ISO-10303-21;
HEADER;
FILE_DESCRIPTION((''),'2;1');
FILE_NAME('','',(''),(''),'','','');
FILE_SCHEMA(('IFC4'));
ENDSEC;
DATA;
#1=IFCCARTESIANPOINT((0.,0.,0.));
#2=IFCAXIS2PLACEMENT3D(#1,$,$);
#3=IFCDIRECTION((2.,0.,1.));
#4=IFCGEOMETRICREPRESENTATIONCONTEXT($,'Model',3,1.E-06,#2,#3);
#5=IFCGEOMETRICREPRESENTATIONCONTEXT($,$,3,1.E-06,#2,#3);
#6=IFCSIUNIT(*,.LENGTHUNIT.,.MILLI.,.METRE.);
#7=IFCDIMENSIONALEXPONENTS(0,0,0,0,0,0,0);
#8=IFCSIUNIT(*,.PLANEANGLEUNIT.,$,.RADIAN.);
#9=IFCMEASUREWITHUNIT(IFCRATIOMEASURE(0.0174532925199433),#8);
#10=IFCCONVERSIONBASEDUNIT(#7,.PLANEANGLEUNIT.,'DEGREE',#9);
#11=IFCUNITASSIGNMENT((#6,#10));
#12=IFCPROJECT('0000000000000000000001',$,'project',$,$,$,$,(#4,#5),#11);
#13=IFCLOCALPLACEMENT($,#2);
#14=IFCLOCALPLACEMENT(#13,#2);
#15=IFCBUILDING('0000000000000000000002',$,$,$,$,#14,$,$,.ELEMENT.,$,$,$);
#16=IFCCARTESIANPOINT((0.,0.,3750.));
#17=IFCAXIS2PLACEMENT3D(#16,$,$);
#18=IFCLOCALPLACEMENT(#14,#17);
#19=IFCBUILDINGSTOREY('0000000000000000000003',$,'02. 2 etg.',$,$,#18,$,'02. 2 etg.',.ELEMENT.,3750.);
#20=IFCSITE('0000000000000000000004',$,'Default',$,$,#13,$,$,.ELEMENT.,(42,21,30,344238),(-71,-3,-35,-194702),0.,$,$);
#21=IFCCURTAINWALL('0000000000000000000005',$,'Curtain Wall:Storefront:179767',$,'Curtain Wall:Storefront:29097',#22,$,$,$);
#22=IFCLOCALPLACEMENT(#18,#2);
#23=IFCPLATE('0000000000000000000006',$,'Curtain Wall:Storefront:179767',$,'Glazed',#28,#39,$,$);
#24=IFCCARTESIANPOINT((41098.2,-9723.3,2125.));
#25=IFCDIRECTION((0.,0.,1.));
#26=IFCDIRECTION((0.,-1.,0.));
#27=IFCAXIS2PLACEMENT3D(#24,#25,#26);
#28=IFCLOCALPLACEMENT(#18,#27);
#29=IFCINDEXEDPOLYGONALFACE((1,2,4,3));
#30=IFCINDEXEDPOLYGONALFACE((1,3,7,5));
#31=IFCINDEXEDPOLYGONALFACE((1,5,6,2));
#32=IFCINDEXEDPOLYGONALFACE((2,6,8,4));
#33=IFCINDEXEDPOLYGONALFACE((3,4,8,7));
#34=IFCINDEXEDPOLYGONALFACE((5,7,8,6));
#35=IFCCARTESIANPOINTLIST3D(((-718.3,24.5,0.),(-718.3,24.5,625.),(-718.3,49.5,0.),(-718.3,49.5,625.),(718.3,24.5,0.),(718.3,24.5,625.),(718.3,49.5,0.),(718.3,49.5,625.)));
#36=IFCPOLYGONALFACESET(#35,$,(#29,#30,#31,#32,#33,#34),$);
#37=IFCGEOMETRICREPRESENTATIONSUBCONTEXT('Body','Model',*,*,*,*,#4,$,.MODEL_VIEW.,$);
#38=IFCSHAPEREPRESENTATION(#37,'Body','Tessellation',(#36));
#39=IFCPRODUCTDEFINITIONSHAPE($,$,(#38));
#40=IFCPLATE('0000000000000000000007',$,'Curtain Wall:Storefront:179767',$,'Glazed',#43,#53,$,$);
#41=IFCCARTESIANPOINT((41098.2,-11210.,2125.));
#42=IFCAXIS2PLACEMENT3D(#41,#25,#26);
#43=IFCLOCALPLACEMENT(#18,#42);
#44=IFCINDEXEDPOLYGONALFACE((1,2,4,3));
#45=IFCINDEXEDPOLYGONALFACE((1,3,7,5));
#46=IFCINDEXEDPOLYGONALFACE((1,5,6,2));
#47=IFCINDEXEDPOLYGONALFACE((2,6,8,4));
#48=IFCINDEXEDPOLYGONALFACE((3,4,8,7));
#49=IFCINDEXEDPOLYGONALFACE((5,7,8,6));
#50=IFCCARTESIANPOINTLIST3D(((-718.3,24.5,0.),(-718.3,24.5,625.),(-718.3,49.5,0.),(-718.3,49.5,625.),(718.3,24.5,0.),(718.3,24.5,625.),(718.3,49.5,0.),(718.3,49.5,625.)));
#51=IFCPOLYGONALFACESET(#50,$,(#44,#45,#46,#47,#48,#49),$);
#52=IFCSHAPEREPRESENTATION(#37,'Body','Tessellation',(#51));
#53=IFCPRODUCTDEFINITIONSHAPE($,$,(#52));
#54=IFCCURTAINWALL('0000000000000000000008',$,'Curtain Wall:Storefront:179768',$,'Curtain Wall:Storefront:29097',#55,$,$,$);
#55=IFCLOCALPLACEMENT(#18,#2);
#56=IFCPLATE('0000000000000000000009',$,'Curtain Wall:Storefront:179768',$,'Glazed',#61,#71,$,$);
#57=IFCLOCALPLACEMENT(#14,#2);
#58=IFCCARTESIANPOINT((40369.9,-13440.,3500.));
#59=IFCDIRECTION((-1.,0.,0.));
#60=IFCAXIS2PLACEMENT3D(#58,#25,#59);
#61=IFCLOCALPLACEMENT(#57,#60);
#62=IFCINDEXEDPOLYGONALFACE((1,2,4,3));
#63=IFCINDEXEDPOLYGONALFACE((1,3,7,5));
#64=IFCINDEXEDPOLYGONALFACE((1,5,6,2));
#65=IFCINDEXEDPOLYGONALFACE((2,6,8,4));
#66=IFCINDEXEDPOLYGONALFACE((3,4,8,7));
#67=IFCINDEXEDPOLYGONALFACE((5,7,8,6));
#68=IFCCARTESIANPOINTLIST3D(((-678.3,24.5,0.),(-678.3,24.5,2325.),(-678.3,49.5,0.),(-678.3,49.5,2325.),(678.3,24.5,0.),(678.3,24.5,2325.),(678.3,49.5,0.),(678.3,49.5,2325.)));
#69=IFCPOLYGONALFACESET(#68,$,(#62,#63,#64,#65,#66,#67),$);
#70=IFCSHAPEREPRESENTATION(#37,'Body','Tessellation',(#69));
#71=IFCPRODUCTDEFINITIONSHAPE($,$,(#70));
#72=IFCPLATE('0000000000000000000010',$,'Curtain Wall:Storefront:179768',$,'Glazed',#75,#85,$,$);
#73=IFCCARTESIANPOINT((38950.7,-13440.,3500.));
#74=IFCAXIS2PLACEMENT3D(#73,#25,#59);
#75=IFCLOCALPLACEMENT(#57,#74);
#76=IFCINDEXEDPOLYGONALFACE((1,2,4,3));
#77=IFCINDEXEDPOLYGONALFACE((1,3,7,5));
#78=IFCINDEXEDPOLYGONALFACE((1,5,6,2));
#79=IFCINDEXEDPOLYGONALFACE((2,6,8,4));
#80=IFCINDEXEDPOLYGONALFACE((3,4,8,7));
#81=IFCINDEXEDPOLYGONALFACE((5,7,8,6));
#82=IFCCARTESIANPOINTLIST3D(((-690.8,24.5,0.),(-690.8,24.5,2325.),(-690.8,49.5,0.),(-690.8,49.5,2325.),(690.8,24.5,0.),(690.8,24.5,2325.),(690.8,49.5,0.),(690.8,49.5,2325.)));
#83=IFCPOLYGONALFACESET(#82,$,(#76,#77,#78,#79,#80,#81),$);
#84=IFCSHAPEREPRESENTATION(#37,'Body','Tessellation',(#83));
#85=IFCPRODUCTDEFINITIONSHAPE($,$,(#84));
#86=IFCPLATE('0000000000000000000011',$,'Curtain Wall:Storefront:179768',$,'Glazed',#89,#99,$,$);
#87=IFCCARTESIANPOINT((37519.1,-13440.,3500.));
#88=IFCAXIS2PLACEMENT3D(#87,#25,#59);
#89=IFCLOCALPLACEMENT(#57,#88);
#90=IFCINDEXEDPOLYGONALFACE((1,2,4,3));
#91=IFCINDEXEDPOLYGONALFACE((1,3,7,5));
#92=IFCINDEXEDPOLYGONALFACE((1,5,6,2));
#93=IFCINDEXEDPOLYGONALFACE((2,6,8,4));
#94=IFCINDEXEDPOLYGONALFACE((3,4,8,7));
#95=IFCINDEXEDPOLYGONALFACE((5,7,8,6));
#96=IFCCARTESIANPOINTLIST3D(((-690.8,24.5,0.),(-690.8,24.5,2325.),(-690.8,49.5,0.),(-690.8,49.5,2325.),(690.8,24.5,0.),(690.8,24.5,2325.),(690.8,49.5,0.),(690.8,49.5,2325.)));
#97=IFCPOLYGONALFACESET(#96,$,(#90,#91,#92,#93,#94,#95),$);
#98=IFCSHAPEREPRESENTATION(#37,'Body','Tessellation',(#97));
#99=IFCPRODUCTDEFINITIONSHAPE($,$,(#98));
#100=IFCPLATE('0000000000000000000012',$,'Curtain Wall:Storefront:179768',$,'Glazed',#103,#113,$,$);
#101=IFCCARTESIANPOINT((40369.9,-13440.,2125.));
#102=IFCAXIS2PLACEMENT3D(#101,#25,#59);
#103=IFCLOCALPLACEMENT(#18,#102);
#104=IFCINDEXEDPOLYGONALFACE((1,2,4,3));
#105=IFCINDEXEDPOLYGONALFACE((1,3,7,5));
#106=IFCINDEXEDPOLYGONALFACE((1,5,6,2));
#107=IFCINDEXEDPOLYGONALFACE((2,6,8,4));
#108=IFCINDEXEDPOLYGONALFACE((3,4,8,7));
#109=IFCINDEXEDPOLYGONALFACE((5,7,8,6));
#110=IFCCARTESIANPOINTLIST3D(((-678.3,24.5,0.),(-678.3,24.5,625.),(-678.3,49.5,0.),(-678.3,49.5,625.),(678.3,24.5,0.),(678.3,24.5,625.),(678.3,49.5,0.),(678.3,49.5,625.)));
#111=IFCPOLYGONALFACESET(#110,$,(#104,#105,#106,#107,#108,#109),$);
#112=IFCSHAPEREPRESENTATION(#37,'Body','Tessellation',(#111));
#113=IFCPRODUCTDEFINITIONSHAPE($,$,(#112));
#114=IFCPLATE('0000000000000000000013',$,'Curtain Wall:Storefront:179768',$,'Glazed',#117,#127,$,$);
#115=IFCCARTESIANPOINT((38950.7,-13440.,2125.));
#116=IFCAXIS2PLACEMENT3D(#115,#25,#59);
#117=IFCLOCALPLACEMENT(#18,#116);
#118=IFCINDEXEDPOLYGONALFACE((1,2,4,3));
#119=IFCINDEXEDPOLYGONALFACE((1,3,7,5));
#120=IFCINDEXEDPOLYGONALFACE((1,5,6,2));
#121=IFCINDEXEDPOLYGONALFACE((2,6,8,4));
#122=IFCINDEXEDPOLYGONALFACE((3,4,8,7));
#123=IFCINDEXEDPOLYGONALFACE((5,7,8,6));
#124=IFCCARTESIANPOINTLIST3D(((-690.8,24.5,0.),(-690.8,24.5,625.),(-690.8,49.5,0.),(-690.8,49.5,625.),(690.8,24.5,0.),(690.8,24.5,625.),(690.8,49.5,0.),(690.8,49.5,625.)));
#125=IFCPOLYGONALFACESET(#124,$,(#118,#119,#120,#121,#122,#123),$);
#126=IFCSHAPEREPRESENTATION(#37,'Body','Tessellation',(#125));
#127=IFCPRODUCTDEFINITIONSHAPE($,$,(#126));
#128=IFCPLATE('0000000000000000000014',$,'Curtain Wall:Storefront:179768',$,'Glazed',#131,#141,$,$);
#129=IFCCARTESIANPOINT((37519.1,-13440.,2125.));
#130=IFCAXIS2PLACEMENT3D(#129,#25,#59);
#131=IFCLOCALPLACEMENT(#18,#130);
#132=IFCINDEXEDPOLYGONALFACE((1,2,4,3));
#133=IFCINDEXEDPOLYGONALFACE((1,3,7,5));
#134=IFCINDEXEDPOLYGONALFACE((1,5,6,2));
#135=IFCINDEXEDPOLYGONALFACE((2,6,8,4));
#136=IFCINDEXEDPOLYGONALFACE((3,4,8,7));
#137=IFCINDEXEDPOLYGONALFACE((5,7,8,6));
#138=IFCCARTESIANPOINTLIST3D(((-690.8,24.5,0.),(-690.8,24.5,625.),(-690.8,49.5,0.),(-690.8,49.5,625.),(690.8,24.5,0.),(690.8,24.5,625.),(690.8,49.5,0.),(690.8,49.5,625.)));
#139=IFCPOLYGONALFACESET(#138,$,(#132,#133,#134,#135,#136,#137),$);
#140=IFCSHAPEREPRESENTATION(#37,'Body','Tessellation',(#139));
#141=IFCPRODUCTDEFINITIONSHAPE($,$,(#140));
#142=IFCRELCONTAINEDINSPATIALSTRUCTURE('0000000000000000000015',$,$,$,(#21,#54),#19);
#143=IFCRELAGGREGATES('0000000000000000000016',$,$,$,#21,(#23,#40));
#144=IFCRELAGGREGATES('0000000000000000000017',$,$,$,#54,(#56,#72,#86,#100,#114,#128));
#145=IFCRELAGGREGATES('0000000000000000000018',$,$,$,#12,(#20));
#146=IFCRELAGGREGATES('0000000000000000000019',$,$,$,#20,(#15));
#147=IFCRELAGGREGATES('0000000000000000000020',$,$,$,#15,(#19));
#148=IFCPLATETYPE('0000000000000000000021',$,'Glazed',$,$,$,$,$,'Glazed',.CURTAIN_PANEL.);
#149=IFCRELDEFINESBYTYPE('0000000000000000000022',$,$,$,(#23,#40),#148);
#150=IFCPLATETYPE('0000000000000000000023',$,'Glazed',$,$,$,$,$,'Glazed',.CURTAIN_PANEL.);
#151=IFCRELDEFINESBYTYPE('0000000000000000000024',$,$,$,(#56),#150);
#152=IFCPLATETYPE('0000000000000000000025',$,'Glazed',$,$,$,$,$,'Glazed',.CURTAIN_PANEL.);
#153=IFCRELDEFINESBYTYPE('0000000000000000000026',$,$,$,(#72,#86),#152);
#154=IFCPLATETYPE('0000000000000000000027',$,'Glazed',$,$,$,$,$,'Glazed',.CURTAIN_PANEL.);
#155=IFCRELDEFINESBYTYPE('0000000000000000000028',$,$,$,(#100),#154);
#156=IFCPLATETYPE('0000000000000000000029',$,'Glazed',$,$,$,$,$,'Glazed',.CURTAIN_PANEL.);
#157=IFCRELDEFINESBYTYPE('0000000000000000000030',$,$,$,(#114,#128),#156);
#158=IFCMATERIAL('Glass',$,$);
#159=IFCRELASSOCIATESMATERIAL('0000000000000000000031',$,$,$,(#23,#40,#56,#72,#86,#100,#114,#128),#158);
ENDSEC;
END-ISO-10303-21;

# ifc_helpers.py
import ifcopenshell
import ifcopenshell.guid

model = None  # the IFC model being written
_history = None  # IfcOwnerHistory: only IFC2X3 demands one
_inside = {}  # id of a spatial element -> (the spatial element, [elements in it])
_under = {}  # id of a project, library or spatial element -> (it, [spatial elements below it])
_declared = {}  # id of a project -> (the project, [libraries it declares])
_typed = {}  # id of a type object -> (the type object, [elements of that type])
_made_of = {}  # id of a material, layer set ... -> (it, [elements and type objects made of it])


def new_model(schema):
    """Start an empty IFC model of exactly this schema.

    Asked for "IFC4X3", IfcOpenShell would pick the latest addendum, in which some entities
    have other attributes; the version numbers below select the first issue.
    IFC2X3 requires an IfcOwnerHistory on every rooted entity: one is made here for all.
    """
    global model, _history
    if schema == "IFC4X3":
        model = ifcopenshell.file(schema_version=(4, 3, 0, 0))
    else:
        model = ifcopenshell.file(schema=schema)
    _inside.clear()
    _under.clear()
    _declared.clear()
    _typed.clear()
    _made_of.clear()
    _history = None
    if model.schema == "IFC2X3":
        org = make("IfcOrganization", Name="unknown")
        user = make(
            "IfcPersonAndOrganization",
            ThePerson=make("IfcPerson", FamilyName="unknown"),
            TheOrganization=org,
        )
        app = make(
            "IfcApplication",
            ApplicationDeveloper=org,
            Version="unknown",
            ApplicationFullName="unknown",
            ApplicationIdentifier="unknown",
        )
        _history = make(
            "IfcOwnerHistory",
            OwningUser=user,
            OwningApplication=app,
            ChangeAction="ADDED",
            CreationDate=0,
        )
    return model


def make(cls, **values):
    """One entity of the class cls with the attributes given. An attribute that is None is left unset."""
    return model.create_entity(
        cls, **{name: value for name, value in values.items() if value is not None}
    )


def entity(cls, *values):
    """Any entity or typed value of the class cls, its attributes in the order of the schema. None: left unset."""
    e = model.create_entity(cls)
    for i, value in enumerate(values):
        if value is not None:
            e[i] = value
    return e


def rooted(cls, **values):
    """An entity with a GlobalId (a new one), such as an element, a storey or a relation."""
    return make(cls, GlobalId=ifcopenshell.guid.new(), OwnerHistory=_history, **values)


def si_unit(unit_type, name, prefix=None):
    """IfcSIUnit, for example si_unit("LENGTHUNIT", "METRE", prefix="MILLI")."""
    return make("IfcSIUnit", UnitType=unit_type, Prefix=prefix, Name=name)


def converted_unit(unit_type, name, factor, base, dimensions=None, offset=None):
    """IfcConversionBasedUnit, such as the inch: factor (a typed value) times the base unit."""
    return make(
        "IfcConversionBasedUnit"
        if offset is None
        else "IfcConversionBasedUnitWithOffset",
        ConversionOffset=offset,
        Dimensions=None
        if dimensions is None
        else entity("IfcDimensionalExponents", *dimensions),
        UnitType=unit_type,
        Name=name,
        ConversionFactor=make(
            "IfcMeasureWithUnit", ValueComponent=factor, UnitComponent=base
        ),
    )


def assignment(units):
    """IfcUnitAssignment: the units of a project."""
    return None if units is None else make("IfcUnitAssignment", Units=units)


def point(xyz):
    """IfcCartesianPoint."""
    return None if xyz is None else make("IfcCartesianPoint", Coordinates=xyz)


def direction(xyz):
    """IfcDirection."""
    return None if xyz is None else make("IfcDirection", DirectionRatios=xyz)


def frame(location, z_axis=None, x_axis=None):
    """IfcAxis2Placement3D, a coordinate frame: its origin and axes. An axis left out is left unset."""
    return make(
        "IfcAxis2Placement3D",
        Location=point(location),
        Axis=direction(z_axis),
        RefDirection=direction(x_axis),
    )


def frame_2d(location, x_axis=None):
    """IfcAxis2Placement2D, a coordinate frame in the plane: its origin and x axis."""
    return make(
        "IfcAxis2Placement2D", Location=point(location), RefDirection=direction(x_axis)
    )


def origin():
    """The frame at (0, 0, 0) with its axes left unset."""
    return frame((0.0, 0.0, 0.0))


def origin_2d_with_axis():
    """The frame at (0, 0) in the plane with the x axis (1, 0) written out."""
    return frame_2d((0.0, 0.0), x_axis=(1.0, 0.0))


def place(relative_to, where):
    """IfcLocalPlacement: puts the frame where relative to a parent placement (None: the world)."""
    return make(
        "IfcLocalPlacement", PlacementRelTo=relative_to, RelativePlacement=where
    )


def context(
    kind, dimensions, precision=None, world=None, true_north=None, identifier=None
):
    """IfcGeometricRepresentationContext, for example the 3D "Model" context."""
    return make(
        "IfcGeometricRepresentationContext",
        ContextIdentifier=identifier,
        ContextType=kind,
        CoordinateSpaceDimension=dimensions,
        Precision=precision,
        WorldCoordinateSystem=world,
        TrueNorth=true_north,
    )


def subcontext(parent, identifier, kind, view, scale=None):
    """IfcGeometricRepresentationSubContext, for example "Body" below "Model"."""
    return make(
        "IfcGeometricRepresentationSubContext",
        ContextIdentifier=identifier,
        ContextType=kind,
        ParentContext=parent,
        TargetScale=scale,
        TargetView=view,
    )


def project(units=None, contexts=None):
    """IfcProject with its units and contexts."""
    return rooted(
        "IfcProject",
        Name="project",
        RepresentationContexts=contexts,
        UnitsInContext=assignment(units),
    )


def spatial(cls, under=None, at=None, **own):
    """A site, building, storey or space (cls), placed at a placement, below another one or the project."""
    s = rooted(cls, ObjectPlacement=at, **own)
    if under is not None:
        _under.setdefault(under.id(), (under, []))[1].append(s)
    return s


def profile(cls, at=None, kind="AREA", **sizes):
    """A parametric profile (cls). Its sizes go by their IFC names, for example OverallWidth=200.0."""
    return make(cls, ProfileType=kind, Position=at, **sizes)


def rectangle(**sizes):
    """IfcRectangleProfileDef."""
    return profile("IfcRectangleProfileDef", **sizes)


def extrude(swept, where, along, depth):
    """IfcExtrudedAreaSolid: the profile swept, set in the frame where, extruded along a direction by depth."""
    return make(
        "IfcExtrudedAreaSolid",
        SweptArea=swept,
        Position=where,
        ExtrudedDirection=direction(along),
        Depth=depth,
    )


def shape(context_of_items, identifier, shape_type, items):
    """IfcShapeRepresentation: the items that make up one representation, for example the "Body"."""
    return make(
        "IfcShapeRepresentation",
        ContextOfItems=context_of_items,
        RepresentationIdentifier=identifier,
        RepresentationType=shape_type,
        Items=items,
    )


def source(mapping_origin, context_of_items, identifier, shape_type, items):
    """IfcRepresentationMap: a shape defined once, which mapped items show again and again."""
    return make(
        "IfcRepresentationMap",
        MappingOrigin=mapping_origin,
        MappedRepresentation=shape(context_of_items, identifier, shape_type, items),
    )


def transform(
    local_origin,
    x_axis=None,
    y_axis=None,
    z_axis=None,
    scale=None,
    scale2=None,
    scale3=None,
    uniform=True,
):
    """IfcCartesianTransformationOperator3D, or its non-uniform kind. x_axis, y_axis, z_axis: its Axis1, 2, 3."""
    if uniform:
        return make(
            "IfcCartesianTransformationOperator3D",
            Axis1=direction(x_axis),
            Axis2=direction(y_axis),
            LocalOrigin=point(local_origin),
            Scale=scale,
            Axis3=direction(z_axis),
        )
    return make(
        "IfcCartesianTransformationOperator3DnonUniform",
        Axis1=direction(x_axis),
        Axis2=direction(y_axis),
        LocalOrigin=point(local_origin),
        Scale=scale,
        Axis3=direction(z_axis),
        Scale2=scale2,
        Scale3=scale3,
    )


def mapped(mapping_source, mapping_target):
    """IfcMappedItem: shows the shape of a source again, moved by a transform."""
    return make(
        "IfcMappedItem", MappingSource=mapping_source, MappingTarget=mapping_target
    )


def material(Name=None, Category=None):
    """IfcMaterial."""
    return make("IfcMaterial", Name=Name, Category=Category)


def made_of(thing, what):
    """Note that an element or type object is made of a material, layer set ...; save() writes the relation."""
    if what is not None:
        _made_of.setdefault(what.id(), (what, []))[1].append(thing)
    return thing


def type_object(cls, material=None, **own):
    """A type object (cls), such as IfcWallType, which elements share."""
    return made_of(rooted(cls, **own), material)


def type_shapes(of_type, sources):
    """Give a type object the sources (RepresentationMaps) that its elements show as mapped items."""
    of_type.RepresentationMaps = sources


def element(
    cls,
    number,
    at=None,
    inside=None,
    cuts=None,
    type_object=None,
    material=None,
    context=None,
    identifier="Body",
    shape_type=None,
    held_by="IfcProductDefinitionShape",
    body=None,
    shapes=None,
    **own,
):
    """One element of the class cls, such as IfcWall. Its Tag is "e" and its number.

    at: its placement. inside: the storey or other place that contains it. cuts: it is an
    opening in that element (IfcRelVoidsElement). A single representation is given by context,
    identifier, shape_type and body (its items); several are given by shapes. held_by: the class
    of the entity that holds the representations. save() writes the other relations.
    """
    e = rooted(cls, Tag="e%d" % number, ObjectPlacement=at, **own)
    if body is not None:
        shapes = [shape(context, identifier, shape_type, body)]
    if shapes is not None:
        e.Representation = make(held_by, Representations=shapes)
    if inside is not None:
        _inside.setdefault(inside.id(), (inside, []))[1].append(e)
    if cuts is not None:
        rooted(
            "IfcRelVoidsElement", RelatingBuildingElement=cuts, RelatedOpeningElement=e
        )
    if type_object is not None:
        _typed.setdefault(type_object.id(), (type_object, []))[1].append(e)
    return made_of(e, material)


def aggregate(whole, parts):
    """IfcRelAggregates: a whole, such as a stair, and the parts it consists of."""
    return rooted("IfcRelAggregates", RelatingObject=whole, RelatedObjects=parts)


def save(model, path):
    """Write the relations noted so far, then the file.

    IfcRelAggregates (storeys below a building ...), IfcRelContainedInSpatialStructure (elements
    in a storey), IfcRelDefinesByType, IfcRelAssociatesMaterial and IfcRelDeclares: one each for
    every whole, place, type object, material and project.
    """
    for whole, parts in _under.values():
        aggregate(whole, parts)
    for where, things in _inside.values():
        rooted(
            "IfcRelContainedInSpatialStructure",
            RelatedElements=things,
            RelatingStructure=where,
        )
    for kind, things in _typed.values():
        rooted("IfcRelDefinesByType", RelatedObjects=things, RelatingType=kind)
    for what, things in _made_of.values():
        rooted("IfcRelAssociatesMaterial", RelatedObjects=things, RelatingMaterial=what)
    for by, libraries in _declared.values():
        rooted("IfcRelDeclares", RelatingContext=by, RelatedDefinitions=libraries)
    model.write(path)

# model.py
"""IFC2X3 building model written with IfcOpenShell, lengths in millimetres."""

from ifc_helpers import new_model, entity, si_unit, converted_unit, direction, frame, origin, origin_2d_with_axis, place, context, subcontext, project, spatial, rectangle, extrude, source, transform, mapped, material, type_object, type_shapes, element, aggregate, save


model = new_model("IFC2X3")

# Units and contexts
model_context = context("Model", 3, precision=1e-06, world=origin(), true_north=direction((2.0, 0.0, 1.0)))
context_of_model = context(None, 3, precision=1e-06, world=origin(), true_north=direction((2.0, 0.0, 1.0)))
body_context = subcontext(model_context, "Body", "Model", "MODEL_VIEW")
ifc_project = project(units=[si_unit("LENGTHUNIT", "METRE", prefix="MILLI"), converted_unit("PLANEANGLEUNIT", "DEGREE", entity("IfcRatioMeasure", 0.0174532925199433), si_unit("PLANEANGLEUNIT", "RADIAN"), dimensions=[0, 0, 0, 0, 0, 0, 0])], contexts=[model_context, context_of_model])

# Site, building, storey
site_placement = place(None, origin())
site = spatial("IfcSite", under=ifc_project, at=site_placement, Name="Default", CompositionType="ELEMENT", RefLatitude=(42, 21, 30, 344238), RefLongitude=(-71, -3, -35, -194702), RefElevation=0.0)
building_placement = place(site_placement, origin())
building = spatial("IfcBuilding", under=site, at=building_placement, CompositionType="ELEMENT")
storey_placement = place(building_placement, frame((0.0, 0.0, 3750.0)))
storey = spatial("IfcBuildingStorey", under=building, at=storey_placement, Name="02. 2 etg.", LongName="02. 2 etg.", CompositionType="ELEMENT", Elevation=3750.0)

# Curtain walls, plates
curtain_wall_1_placement = place(storey_placement, origin())
curtain_wall_1 = element("IfcCurtainWall", 1, at=curtain_wall_1_placement, inside=storey, Name="Curtain Wall:Storefront:179767", ObjectType="Curtain Wall:Storefront:29097")
ifc_material_1 = material(Name="Glass")
placement = place(building_placement, origin())
plate_type_1 = type_object("IfcPlateType", Name="Glazed", ElementType="Glazed", PredefinedType="CURTAIN_PANEL")
shared_shape_1 = source(origin(), body_context, "Body", "SweptSolid", [
    extrude(rectangle(XDim=25.0, YDim=1436.7, at=origin_2d_with_axis()), frame((0.0, 37.0, 0.0), z_axis=(0.0, 0.0, 1.0), x_axis=(0.0, 1.0, 0.0)), (0.0, 0.0, 1.0), 625.0),
])
type_shapes(plate_type_1, [shared_shape_1])
plate_1_placement = place(storey_placement, frame((41098.2, -9723.3, 2125.0), z_axis=(0.0, 0.0, 1.0), x_axis=(0.0, -1.0, 0.0)))
plate_1 = element("IfcPlate", 2, at=plate_1_placement, type_object=plate_type_1, material=ifc_material_1, Name="Curtain Wall:Storefront:179767", ObjectType="Glazed", context=body_context, shape_type="MappedRepresentation", body=[
    mapped(shared_shape_1, transform((0.0, 0.0, 0.0), scale=1.0)),
])
plate_2_placement = place(storey_placement, frame((41098.2, -11210.0, 2125.0), z_axis=(0.0, 0.0, 1.0), x_axis=(0.0, -1.0, 0.0)))
plate_2 = element("IfcPlate", 3, at=plate_2_placement, type_object=plate_type_1, material=ifc_material_1, Name="Curtain Wall:Storefront:179767", ObjectType="Glazed", context=body_context, shape_type="MappedRepresentation", body=[
    mapped(shared_shape_1, transform((0.0, 0.0, 0.0), scale=1.0)),
])
aggregate(curtain_wall_1, [plate_1, plate_2])
curtain_wall_2_placement = place(storey_placement, origin())
curtain_wall_2 = element("IfcCurtainWall", 4, at=curtain_wall_2_placement, inside=storey, Name="Curtain Wall:Storefront:179768", ObjectType="Curtain Wall:Storefront:29097")
plate_type_2 = type_object("IfcPlateType", Name="Glazed", ElementType="Glazed", PredefinedType="CURTAIN_PANEL")
shared_shape_2 = source(origin(), body_context, "Body", "SweptSolid", [
    extrude(rectangle(XDim=25.0, YDim=1356.7, at=origin_2d_with_axis()), frame((0.0, 37.0, 0.0), z_axis=(0.0, 0.0, 1.0), x_axis=(0.0, 1.0, 0.0)), (0.0, 0.0, 1.0), 2325.0),
])
type_shapes(plate_type_2, [shared_shape_2])
plate_3_placement = place(placement, frame((40369.9, -13440.0, 3500.0), z_axis=(0.0, 0.0, 1.0), x_axis=(-1.0, 0.0, 0.0)))
plate_3 = element("IfcPlate", 5, at=plate_3_placement, type_object=plate_type_2, material=ifc_material_1, Name="Curtain Wall:Storefront:179768", ObjectType="Glazed", context=body_context, shape_type="MappedRepresentation", body=[
    mapped(shared_shape_2, transform((0.0, 0.0, 0.0), scale=1.0)),
])
plate_type_3 = type_object("IfcPlateType", Name="Glazed", ElementType="Glazed", PredefinedType="CURTAIN_PANEL")
shared_shape_3 = source(origin(), body_context, "Body", "SweptSolid", [
    extrude(rectangle(XDim=25.0, YDim=1381.7, at=origin_2d_with_axis()), frame((0.0, 37.0, 0.0), z_axis=(0.0, 0.0, 1.0), x_axis=(0.0, 1.0, 0.0)), (0.0, 0.0, 1.0), 2325.0),
])
type_shapes(plate_type_3, [shared_shape_3])
plate_4_placement = place(placement, frame((38950.7, -13440.0, 3500.0), z_axis=(0.0, 0.0, 1.0), x_axis=(-1.0, 0.0, 0.0)))
plate_4 = element("IfcPlate", 6, at=plate_4_placement, type_object=plate_type_3, material=ifc_material_1, Name="Curtain Wall:Storefront:179768", ObjectType="Glazed", context=body_context, shape_type="MappedRepresentation", body=[
    mapped(shared_shape_3, transform((0.0, 0.0, 0.0), scale=1.0)),
])
plate_5_placement = place(placement, frame((37519.1, -13440.0, 3500.0), z_axis=(0.0, 0.0, 1.0), x_axis=(-1.0, 0.0, 0.0)))
plate_5 = element("IfcPlate", 7, at=plate_5_placement, type_object=plate_type_3, material=ifc_material_1, Name="Curtain Wall:Storefront:179768", ObjectType="Glazed", context=body_context, shape_type="MappedRepresentation", body=[
    mapped(shared_shape_3, transform((0.0, 0.0, 0.0), scale=1.0)),
])
plate_type_4 = type_object("IfcPlateType", Name="Glazed", ElementType="Glazed", PredefinedType="CURTAIN_PANEL")
shared_shape_4 = source(origin(), body_context, "Body", "SweptSolid", [
    extrude(rectangle(XDim=25.0, YDim=1356.7, at=origin_2d_with_axis()), frame((0.0, 37.0, 0.0), z_axis=(0.0, 0.0, 1.0), x_axis=(0.0, 1.0, 0.0)), (0.0, 0.0, 1.0), 625.0),
])
type_shapes(plate_type_4, [shared_shape_4])
plate_6_placement = place(storey_placement, frame((40369.9, -13440.0, 2125.0), z_axis=(0.0, 0.0, 1.0), x_axis=(-1.0, 0.0, 0.0)))
plate_6 = element("IfcPlate", 8, at=plate_6_placement, type_object=plate_type_4, material=ifc_material_1, Name="Curtain Wall:Storefront:179768", ObjectType="Glazed", context=body_context, shape_type="MappedRepresentation", body=[
    mapped(shared_shape_4, transform((0.0, 0.0, 0.0), scale=1.0)),
])
plate_type_5 = type_object("IfcPlateType", Name="Glazed", ElementType="Glazed", PredefinedType="CURTAIN_PANEL")
shared_shape_5 = source(origin(), body_context, "Body", "SweptSolid", [
    extrude(rectangle(XDim=25.0, YDim=1381.7, at=origin_2d_with_axis()), frame((0.0, 37.0, 0.0), z_axis=(0.0, 0.0, 1.0), x_axis=(0.0, 1.0, 0.0)), (0.0, 0.0, 1.0), 625.0),
])
type_shapes(plate_type_5, [shared_shape_5])
plate_7_placement = place(storey_placement, frame((38950.7, -13440.0, 2125.0), z_axis=(0.0, 0.0, 1.0), x_axis=(-1.0, 0.0, 0.0)))
plate_7 = element("IfcPlate", 9, at=plate_7_placement, type_object=plate_type_5, material=ifc_material_1, Name="Curtain Wall:Storefront:179768", ObjectType="Glazed", context=body_context, shape_type="MappedRepresentation", body=[
    mapped(shared_shape_5, transform((0.0, 0.0, 0.0), scale=1.0)),
])
plate_8_placement = place(storey_placement, frame((37519.1, -13440.0, 2125.0), z_axis=(0.0, 0.0, 1.0), x_axis=(-1.0, 0.0, 0.0)))
plate_8 = element("IfcPlate", 10, at=plate_8_placement, type_object=plate_type_5, material=ifc_material_1, Name="Curtain Wall:Storefront:179768", ObjectType="Glazed", context=body_context, shape_type="MappedRepresentation", body=[
    mapped(shared_shape_5, transform((0.0, 0.0, 0.0), scale=1.0)),
])
aggregate(curtain_wall_2, [plate_3, plate_4, plate_5, plate_6, plate_7, plate_8])

save(model, "model.ifc")
